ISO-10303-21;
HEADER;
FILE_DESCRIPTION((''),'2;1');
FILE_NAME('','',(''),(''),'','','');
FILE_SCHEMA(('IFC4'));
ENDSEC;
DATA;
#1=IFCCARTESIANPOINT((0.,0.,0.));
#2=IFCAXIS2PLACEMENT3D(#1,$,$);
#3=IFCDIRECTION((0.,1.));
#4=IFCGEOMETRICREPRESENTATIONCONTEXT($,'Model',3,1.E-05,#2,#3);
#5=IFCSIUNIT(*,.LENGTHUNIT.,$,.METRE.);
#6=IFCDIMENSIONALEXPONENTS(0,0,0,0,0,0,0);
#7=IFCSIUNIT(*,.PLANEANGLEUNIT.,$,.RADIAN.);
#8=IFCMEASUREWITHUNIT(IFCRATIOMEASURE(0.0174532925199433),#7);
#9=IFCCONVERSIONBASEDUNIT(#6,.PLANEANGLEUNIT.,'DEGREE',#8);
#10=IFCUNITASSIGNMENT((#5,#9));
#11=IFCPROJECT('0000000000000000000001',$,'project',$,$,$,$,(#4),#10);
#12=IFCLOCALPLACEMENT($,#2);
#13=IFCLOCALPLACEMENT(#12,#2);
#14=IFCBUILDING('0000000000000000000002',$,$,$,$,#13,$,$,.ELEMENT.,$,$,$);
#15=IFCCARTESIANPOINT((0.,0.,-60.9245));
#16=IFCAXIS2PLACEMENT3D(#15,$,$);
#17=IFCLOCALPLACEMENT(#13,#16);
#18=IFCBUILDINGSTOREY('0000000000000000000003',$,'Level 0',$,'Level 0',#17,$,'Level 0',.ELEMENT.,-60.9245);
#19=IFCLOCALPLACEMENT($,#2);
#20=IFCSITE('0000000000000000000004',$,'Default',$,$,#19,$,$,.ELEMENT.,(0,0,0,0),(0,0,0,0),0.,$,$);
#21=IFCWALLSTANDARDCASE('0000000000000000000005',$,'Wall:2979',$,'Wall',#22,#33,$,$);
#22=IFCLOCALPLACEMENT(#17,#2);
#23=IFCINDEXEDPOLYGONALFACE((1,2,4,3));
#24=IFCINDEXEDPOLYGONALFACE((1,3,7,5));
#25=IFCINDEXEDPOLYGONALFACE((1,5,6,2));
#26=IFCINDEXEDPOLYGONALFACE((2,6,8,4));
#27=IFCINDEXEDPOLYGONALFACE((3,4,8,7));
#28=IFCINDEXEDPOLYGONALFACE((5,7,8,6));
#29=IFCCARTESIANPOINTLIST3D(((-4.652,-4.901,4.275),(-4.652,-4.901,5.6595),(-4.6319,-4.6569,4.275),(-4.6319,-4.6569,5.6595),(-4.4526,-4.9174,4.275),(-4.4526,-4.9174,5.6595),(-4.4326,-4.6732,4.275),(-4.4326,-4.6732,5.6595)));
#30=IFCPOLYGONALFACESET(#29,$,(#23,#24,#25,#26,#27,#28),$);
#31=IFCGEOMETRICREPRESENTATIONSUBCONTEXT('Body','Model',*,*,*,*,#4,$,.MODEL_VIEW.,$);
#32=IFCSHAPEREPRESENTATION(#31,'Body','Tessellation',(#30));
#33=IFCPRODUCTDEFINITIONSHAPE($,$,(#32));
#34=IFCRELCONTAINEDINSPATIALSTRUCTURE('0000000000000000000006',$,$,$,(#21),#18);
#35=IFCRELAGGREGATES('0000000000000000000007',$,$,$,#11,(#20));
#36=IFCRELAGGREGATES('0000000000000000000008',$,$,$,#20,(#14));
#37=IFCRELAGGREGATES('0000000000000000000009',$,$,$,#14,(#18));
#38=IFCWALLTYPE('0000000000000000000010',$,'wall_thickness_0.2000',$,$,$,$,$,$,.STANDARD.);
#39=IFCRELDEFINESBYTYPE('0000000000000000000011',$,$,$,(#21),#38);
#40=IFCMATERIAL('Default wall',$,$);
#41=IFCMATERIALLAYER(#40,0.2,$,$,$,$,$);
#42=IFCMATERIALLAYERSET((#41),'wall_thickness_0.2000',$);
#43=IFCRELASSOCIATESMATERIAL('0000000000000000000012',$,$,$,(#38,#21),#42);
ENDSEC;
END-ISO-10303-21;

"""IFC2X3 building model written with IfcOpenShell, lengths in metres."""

from ifc_helpers import new_model, entity, si_unit, converted_unit, direction, frame, origin, place, context, subcontext, project, spatial, polyline, outline, extrude, material, layer, layer_set, layer_usage, type_object, element, save


model = new_model("IFC2X3")

# Units and contexts
model_context = context("Model", 3, precision=1e-05, world=origin(), true_north=direction((0.0, 1.0)))
body_context = subcontext(model_context, "Body", "Model", "MODEL_VIEW")
ifc_project = project(units=[si_unit("LENGTHUNIT", "METRE"), converted_unit("PLANEANGLEUNIT", "DEGREE", entity("IfcRatioMeasure", 0.0174532925199433), si_unit("PLANEANGLEUNIT", "RADIAN"), dimensions=[0, 0, 0, 0, 0, 0, 0])], contexts=[model_context])

# Site, building, storey
site_placement = place(None, origin())
site = spatial("IfcSite", under=ifc_project, at=site_placement, Name="Default", CompositionType="ELEMENT", RefLatitude=(0, 0, 0, 0), RefLongitude=(0, 0, 0, 0), RefElevation=0.0)
placement_1 = place(None, origin())
building_placement = place(placement_1, origin())
building = spatial("IfcBuilding", under=site, at=building_placement, CompositionType="ELEMENT")
storey_placement = place(building_placement, frame((0.0, 0.0, -60.9245)))
storey = spatial("IfcBuildingStorey", under=building, at=storey_placement, Name="Level 0", ObjectType="Level 0", LongName="Level 0", CompositionType="ELEMENT", Elevation=-60.9245)

# Shared definitions
ifc_material_1 = material(Name="Default wall")
ifc_layer = layer(ifc_material_1, 0.2)
ifc_layer_set = layer_set([ifc_layer], Name="wall_thickness_0.2000")
ifc_layer_usage = layer_usage(ifc_layer_set, "AXIS2", "POSITIVE", -0.1)
wall_type = type_object("IfcWallType", Name="wall_thickness_0.2000", PredefinedType="STANDARD", material=ifc_layer_set)

# Wall
placement_2 = place(building_placement, frame((0.0, 0.0, -56.6495)))
wall_1_placement = place(placement_2, frame((-4.5323, -4.665, 0.0), z_axis=(0.0, 0.0, 1.0), x_axis=(-0.081738, -0.996654, 0.0)))
element("IfcWallStandardCase", 1, at=wall_1_placement, inside=storey, type_object=wall_type, material=ifc_layer_usage, Name="Wall:2979", ObjectType="Wall", context=body_context, shape_type="SweptSolid", body=[
    extrude(outline(polyline([(0.245, -0.1), (0.245, 0.1), (0.0, 0.1), (0.0, -0.1), (0.245, -0.1)])), origin(), (0.0, 0.0, 1.0), 1.3845),
])

save(model, "model.ifc")
